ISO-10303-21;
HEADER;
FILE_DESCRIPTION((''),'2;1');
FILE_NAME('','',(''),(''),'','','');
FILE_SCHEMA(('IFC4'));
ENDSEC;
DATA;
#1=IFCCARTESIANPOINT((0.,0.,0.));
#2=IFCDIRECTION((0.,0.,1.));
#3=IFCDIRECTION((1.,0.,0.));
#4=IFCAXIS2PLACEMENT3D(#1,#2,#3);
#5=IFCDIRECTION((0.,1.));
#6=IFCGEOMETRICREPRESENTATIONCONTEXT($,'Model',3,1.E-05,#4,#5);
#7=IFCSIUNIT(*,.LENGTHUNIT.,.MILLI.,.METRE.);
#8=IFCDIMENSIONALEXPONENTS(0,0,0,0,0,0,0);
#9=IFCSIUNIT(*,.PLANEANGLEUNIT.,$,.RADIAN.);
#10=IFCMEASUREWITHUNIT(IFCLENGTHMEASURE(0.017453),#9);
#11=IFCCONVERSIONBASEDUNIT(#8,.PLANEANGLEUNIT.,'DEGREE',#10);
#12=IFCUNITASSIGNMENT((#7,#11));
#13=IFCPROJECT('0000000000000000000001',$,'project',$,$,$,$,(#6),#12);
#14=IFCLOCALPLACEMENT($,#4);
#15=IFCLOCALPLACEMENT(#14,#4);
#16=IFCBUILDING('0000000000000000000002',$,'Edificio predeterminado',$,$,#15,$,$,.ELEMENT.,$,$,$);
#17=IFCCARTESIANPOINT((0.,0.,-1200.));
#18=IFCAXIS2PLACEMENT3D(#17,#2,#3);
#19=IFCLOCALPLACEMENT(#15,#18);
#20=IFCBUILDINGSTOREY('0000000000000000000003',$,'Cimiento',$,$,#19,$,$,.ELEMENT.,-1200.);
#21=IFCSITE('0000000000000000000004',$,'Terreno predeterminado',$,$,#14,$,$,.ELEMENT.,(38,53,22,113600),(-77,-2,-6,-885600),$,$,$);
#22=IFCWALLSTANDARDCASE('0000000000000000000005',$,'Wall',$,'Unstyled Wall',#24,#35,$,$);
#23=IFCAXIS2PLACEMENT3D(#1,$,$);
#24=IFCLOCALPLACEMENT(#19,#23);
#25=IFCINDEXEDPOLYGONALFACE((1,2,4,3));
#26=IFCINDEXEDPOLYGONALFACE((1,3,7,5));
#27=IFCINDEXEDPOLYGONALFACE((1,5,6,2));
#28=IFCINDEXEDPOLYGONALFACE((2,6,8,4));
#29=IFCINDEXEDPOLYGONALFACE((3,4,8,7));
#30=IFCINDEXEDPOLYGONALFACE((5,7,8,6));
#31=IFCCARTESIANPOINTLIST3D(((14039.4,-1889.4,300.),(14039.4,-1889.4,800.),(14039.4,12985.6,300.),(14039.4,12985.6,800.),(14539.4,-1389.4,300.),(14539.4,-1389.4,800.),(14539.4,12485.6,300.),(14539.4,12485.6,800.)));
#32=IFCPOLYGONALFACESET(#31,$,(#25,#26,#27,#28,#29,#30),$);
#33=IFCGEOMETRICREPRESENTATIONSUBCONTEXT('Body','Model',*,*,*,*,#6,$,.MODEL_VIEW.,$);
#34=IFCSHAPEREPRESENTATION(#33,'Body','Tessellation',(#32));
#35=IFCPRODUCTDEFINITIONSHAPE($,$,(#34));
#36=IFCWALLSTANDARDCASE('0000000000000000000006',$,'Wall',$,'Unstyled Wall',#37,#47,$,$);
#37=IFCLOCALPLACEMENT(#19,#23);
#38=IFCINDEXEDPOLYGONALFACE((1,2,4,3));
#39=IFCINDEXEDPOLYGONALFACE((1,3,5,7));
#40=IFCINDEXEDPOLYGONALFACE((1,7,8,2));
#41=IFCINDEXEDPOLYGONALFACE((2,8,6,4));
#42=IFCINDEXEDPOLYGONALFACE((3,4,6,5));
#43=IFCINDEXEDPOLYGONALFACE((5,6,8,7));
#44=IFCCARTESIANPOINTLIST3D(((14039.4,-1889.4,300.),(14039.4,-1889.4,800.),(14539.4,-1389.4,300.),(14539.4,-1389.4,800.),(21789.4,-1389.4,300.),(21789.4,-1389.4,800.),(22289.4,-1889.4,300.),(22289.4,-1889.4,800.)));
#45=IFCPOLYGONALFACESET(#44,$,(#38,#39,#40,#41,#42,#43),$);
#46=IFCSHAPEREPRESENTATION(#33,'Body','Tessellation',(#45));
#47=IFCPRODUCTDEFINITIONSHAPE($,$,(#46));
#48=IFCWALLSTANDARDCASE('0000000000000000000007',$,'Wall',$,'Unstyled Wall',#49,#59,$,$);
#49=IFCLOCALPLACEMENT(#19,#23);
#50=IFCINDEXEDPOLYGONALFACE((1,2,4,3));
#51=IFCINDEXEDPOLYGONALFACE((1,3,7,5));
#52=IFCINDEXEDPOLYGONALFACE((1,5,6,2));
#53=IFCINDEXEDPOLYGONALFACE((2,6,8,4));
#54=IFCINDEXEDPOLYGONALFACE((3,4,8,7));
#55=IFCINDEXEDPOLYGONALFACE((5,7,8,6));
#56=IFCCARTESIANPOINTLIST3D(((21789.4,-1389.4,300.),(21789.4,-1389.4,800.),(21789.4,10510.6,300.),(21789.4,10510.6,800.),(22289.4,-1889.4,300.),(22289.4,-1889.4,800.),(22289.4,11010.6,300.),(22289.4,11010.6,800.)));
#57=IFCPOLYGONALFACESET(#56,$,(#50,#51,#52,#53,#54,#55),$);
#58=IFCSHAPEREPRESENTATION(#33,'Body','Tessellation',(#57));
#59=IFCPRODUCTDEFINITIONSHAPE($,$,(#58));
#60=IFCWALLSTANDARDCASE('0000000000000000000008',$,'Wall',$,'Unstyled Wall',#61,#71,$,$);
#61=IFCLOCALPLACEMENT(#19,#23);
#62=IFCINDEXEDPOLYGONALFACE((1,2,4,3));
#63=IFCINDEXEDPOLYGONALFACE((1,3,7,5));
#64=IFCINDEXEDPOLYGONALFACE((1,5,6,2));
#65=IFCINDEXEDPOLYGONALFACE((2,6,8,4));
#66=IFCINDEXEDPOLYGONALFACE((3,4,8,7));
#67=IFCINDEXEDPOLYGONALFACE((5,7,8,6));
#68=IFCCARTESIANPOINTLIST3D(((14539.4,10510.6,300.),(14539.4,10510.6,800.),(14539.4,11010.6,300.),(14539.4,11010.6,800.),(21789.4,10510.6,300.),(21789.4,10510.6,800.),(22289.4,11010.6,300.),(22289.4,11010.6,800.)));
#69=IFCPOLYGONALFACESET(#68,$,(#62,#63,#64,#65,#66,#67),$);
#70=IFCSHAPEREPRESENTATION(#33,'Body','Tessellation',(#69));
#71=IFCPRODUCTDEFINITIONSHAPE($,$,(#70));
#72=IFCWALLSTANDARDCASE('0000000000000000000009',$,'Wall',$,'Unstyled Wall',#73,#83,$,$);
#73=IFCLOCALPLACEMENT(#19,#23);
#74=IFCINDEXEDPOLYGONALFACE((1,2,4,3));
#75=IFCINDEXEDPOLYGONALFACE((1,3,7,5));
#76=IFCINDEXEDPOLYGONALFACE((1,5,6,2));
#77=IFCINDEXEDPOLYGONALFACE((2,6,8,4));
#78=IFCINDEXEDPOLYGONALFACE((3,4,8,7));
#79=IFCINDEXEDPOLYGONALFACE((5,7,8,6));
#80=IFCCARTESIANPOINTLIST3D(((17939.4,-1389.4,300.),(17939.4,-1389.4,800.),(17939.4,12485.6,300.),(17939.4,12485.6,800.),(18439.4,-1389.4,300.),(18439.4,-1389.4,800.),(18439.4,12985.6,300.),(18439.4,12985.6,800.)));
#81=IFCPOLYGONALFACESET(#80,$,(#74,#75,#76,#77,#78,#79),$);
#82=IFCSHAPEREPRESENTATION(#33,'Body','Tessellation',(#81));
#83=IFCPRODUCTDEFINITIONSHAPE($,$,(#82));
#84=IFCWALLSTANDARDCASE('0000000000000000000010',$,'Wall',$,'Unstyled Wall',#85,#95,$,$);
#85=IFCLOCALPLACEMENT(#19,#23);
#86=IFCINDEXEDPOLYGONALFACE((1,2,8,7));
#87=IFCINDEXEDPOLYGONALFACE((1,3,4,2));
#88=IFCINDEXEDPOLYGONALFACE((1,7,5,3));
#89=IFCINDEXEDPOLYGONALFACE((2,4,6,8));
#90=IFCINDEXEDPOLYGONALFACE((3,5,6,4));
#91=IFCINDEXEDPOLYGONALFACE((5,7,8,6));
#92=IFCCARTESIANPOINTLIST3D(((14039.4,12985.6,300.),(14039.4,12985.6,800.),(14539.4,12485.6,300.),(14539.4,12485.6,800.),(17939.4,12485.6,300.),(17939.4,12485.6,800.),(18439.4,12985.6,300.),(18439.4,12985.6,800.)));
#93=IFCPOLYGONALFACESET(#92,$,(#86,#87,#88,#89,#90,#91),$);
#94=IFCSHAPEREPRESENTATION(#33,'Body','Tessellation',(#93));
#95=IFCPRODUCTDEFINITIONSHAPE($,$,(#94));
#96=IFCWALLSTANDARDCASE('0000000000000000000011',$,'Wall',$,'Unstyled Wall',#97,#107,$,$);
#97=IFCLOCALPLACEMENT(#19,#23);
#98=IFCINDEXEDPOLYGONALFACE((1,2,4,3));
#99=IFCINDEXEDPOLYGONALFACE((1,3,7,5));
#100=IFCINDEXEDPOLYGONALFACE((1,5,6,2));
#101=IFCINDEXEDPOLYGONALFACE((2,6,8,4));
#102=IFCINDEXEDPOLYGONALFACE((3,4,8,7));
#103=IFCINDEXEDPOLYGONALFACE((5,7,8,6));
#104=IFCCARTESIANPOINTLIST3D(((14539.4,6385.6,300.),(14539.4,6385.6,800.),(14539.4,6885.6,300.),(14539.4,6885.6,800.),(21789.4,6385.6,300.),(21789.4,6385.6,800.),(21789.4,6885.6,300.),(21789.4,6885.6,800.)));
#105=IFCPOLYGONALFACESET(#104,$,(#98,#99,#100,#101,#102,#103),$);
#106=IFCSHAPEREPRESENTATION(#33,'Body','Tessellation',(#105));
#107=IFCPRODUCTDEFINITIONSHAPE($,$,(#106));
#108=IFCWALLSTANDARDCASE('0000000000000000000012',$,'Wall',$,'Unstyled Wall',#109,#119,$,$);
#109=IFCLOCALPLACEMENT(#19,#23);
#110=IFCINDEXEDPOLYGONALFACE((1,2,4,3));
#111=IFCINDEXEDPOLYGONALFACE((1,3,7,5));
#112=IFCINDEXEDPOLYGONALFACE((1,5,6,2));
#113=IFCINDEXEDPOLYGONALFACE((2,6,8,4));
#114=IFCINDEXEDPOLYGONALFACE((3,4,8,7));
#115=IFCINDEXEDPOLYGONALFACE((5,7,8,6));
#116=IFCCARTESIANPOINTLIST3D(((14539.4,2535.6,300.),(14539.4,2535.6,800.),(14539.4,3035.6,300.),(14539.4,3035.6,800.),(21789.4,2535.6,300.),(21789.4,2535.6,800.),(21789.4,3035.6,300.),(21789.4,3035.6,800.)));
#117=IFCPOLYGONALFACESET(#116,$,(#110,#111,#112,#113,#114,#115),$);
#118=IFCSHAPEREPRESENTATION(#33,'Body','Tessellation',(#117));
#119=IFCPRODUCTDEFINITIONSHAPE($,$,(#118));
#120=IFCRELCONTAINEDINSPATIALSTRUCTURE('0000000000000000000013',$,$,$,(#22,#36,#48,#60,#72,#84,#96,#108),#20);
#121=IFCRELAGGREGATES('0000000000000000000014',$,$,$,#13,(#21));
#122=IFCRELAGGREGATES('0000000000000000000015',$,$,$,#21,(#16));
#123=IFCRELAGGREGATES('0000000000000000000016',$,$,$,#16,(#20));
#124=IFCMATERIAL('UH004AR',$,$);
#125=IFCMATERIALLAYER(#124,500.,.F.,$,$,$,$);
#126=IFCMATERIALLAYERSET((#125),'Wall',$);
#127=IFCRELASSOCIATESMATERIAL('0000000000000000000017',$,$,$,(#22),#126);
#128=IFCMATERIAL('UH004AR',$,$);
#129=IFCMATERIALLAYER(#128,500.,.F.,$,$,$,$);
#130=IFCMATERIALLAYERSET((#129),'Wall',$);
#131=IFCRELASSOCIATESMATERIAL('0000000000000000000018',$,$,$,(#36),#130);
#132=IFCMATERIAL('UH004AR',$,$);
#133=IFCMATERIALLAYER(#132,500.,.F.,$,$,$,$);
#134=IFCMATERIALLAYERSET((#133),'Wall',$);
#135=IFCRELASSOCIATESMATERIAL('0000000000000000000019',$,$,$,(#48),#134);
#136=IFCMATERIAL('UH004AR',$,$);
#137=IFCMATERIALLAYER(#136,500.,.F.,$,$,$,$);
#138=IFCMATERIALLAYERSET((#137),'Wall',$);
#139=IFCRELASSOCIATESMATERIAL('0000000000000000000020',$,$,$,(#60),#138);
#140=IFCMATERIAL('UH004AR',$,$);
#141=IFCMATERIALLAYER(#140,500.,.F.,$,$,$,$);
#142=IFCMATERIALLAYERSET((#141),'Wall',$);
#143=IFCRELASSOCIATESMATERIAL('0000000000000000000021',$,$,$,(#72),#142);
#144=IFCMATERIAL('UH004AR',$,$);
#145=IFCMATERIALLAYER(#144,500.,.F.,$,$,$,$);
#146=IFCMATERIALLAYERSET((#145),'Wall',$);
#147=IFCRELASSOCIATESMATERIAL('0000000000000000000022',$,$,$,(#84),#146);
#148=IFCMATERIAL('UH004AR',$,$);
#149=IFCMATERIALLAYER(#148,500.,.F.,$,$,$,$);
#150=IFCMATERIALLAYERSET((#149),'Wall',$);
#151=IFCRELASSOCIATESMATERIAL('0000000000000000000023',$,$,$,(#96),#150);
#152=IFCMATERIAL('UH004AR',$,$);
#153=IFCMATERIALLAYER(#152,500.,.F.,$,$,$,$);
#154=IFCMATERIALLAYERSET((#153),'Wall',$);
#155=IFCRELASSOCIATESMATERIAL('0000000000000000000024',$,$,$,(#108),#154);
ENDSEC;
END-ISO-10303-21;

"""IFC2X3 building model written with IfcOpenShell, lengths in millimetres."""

from ifc_helpers import new_model, entity, si_unit, converted_unit, direction, frame, origin_with_axes, place, context, subcontext, project, spatial, polyline, outline, extrude, material, layer, layer_set, layer_usage, element, save


model = new_model("IFC2X3")

# Units and contexts
model_context = context("Model", 3, precision=1e-05, world=origin_with_axes(), true_north=direction((0.0, 1.0)))
body_context = subcontext(model_context, "Body", "Model", "MODEL_VIEW")
ifc_project = project(units=[si_unit("LENGTHUNIT", "METRE", prefix="MILLI"), converted_unit("PLANEANGLEUNIT", "DEGREE", entity("IfcLengthMeasure", 0.017453), si_unit("PLANEANGLEUNIT", "RADIAN"), dimensions=[0, 0, 0, 0, 0, 0, 0])], contexts=[model_context])

# Site, building, storey
site_placement = place(None, origin_with_axes())
site = spatial("IfcSite", under=ifc_project, at=site_placement, Name="Terreno predeterminado", CompositionType="ELEMENT", RefLatitude=(38, 53, 22, 113600), RefLongitude=(-77, -2, -6, -885600))
building_placement = place(site_placement, origin_with_axes())
building = spatial("IfcBuilding", under=site, at=building_placement, Name="Edificio predeterminado", CompositionType="ELEMENT")
storey_placement = place(building_placement, frame((0.0, 0.0, -1200.0), z_axis=(0.0, 0.0, 1.0), x_axis=(1.0, 0.0, 0.0)))
storey = spatial("IfcBuildingStorey", under=building, at=storey_placement, Name="Cimiento", CompositionType="ELEMENT", Elevation=-1200.0)

# Walls
ifc_material_1 = material(Name="UH004AR")
ifc_layer_1 = layer(ifc_material_1, 500.0, ventilated=False)
ifc_layer_set_1 = layer_set([ifc_layer_1], Name="Wall")
ifc_layer_usage_1 = layer_usage(ifc_layer_set_1, "AXIS2", "POSITIVE", -250.0)
wall_1_placement = place(storey_placement, frame((14289.4, 12735.6, 300.0), z_axis=(0.0, 0.0, 1.0), x_axis=(0.0, -1.0, 0.0)))
element("IfcWallStandardCase", 1, at=wall_1_placement, inside=storey, material=ifc_layer_usage_1, Name="Wall", ObjectType="Unstyled Wall", context=body_context, shape_type="SweptSolid", body=[
    extrude(outline(polyline([(250.0, 250.0), (-250.0, -250.0), (14625.0, -250.0), (14125.0, 250.0), (250.0, 250.0)])), origin_with_axes(), (0.0, 0.0, 1.0), 500.0),
])
ifc_material_2 = material(Name="UH004AR")
ifc_layer_2 = layer(ifc_material_2, 500.0, ventilated=False)
ifc_layer_set_2 = layer_set([ifc_layer_2], Name="Wall")
ifc_layer_usage_2 = layer_usage(ifc_layer_set_2, "AXIS2", "POSITIVE", -250.0)
wall_2_placement = place(storey_placement, frame((14289.4, -1639.4, 300.0), z_axis=(0.0, 0.0, 1.0), x_axis=(1.0, 0.0, 0.0)))
element("IfcWallStandardCase", 2, at=wall_2_placement, inside=storey, material=ifc_layer_usage_2, Name="Wall", ObjectType="Unstyled Wall", context=body_context, shape_type="SweptSolid", body=[
    extrude(outline(polyline([(-250.0, -250.0), (250.0, 250.0), (7500.0, 250.0), (8000.0, -250.0), (-250.0, -250.0)])), origin_with_axes(), (0.0, 0.0, 1.0), 500.0),
])
ifc_material_3 = material(Name="UH004AR")
ifc_layer_3 = layer(ifc_material_3, 500.0, ventilated=False)
ifc_layer_set_3 = layer_set([ifc_layer_3], Name="Wall")
ifc_layer_usage_3 = layer_usage(ifc_layer_set_3, "AXIS2", "POSITIVE", -250.0)
wall_3_placement = place(storey_placement, frame((22039.4, -1639.4, 300.0), z_axis=(0.0, 0.0, 1.0), x_axis=(0.0, 1.0, 0.0)))
element("IfcWallStandardCase", 3, at=wall_3_placement, inside=storey, material=ifc_layer_usage_3, Name="Wall", ObjectType="Unstyled Wall", context=body_context, shape_type="SweptSolid", body=[
    extrude(outline(polyline([(-250.0, -250.0), (250.0, 250.0), (12150.0, 250.0), (12650.0, -250.0), (-250.0, -250.0)])), origin_with_axes(), (0.0, 0.0, 1.0), 500.0),
])
ifc_material_4 = material(Name="UH004AR")
ifc_layer_4 = layer(ifc_material_4, 500.0, ventilated=False)
ifc_layer_set_4 = layer_set([ifc_layer_4], Name="Wall")
ifc_layer_usage_4 = layer_usage(ifc_layer_set_4, "AXIS2", "POSITIVE", -250.0)
wall_4_placement = place(storey_placement, frame((22039.4, 10760.6, 300.0), z_axis=(0.0, 0.0, 1.0), x_axis=(-1.0, 0.0, 0.0)))
element("IfcWallStandardCase", 4, at=wall_4_placement, inside=storey, material=ifc_layer_usage_4, Name="Wall", ObjectType="Unstyled Wall", context=body_context, shape_type="SweptSolid", body=[
    extrude(outline(polyline([(-250.0, -250.0), (250.0, 250.0), (7500.0, 250.0), (7500.0, -250.0), (-250.0, -250.0)])), origin_with_axes(), (0.0, 0.0, 1.0), 500.0),
])
ifc_material_5 = material(Name="UH004AR")
ifc_layer_5 = layer(ifc_material_5, 500.0, ventilated=False)
ifc_layer_set_5 = layer_set([ifc_layer_5], Name="Wall")
ifc_layer_usage_5 = layer_usage(ifc_layer_set_5, "AXIS2", "POSITIVE", -250.0)
wall_5_placement = place(storey_placement, frame((18189.4, -1639.4, 300.0), z_axis=(0.0, 0.0, 1.0), x_axis=(0.0, 1.0, 0.0)))
element("IfcWallStandardCase", 5, at=wall_5_placement, inside=storey, material=ifc_layer_usage_5, Name="Wall", ObjectType="Unstyled Wall", context=body_context, shape_type="SweptSolid", body=[
    extrude(outline(polyline([(250.0, 250.0), (250.0, -250.0), (14625.0, -250.0), (14125.0, 250.0), (250.0, 250.0)])), origin_with_axes(), (0.0, 0.0, 1.0), 500.0),
])
ifc_material_6 = material(Name="UH004AR")
ifc_layer_6 = layer(ifc_material_6, 500.0, ventilated=False)
ifc_layer_set_6 = layer_set([ifc_layer_6], Name="Wall")
ifc_layer_usage_6 = layer_usage(ifc_layer_set_6, "AXIS2", "POSITIVE", -250.0)
wall_6_placement = place(storey_placement, frame((18189.4, 12735.6, 300.0), z_axis=(0.0, 0.0, 1.0), x_axis=(-1.0, 0.0, 0.0)))
element("IfcWallStandardCase", 6, at=wall_6_placement, inside=storey, material=ifc_layer_usage_6, Name="Wall", ObjectType="Unstyled Wall", context=body_context, shape_type="SweptSolid", body=[
    extrude(outline(polyline([(-250.0, -250.0), (250.0, 250.0), (3650.0, 250.0), (4150.0, -250.0), (-250.0, -250.0)])), origin_with_axes(), (0.0, 0.0, 1.0), 500.0),
])
ifc_material_7 = material(Name="UH004AR")
ifc_layer_7 = layer(ifc_material_7, 500.0, ventilated=False)
ifc_layer_set_7 = layer_set([ifc_layer_7], Name="Wall")
ifc_layer_usage_7 = layer_usage(ifc_layer_set_7, "AXIS2", "POSITIVE", -250.0)
wall_7_placement = place(storey_placement, frame((14289.4, 6635.6, 300.0), z_axis=(0.0, 0.0, 1.0), x_axis=(1.0, 0.0, 0.0)))
element("IfcWallStandardCase", 7, at=wall_7_placement, inside=storey, material=ifc_layer_usage_7, Name="Wall", ObjectType="Unstyled Wall", context=body_context, shape_type="SweptSolid", body=[
    extrude(outline(polyline([(250.0, -250.0), (250.0, 250.0), (7500.0, 250.0), (7500.0, -250.0), (250.0, -250.0)])), origin_with_axes(), (0.0, 0.0, 1.0), 500.0),
])
ifc_material_8 = material(Name="UH004AR")
ifc_layer_8 = layer(ifc_material_8, 500.0, ventilated=False)
ifc_layer_set_8 = layer_set([ifc_layer_8], Name="Wall")
ifc_layer_usage_8 = layer_usage(ifc_layer_set_8, "AXIS2", "POSITIVE", -250.0)
wall_8_placement = place(storey_placement, frame((14289.4, 2785.6, 300.0), z_axis=(0.0, 0.0, 1.0), x_axis=(1.0, 0.0, 0.0)))
element("IfcWallStandardCase", 8, at=wall_8_placement, inside=storey, material=ifc_layer_usage_8, Name="Wall", ObjectType="Unstyled Wall", context=body_context, shape_type="SweptSolid", body=[
    extrude(outline(polyline([(250.0, -250.0), (250.0, 250.0), (7500.0, 250.0), (7500.0, -250.0), (250.0, -250.0)])), origin_with_axes(), (0.0, 0.0, 1.0), 500.0),
])

save(model, "model.ifc")
